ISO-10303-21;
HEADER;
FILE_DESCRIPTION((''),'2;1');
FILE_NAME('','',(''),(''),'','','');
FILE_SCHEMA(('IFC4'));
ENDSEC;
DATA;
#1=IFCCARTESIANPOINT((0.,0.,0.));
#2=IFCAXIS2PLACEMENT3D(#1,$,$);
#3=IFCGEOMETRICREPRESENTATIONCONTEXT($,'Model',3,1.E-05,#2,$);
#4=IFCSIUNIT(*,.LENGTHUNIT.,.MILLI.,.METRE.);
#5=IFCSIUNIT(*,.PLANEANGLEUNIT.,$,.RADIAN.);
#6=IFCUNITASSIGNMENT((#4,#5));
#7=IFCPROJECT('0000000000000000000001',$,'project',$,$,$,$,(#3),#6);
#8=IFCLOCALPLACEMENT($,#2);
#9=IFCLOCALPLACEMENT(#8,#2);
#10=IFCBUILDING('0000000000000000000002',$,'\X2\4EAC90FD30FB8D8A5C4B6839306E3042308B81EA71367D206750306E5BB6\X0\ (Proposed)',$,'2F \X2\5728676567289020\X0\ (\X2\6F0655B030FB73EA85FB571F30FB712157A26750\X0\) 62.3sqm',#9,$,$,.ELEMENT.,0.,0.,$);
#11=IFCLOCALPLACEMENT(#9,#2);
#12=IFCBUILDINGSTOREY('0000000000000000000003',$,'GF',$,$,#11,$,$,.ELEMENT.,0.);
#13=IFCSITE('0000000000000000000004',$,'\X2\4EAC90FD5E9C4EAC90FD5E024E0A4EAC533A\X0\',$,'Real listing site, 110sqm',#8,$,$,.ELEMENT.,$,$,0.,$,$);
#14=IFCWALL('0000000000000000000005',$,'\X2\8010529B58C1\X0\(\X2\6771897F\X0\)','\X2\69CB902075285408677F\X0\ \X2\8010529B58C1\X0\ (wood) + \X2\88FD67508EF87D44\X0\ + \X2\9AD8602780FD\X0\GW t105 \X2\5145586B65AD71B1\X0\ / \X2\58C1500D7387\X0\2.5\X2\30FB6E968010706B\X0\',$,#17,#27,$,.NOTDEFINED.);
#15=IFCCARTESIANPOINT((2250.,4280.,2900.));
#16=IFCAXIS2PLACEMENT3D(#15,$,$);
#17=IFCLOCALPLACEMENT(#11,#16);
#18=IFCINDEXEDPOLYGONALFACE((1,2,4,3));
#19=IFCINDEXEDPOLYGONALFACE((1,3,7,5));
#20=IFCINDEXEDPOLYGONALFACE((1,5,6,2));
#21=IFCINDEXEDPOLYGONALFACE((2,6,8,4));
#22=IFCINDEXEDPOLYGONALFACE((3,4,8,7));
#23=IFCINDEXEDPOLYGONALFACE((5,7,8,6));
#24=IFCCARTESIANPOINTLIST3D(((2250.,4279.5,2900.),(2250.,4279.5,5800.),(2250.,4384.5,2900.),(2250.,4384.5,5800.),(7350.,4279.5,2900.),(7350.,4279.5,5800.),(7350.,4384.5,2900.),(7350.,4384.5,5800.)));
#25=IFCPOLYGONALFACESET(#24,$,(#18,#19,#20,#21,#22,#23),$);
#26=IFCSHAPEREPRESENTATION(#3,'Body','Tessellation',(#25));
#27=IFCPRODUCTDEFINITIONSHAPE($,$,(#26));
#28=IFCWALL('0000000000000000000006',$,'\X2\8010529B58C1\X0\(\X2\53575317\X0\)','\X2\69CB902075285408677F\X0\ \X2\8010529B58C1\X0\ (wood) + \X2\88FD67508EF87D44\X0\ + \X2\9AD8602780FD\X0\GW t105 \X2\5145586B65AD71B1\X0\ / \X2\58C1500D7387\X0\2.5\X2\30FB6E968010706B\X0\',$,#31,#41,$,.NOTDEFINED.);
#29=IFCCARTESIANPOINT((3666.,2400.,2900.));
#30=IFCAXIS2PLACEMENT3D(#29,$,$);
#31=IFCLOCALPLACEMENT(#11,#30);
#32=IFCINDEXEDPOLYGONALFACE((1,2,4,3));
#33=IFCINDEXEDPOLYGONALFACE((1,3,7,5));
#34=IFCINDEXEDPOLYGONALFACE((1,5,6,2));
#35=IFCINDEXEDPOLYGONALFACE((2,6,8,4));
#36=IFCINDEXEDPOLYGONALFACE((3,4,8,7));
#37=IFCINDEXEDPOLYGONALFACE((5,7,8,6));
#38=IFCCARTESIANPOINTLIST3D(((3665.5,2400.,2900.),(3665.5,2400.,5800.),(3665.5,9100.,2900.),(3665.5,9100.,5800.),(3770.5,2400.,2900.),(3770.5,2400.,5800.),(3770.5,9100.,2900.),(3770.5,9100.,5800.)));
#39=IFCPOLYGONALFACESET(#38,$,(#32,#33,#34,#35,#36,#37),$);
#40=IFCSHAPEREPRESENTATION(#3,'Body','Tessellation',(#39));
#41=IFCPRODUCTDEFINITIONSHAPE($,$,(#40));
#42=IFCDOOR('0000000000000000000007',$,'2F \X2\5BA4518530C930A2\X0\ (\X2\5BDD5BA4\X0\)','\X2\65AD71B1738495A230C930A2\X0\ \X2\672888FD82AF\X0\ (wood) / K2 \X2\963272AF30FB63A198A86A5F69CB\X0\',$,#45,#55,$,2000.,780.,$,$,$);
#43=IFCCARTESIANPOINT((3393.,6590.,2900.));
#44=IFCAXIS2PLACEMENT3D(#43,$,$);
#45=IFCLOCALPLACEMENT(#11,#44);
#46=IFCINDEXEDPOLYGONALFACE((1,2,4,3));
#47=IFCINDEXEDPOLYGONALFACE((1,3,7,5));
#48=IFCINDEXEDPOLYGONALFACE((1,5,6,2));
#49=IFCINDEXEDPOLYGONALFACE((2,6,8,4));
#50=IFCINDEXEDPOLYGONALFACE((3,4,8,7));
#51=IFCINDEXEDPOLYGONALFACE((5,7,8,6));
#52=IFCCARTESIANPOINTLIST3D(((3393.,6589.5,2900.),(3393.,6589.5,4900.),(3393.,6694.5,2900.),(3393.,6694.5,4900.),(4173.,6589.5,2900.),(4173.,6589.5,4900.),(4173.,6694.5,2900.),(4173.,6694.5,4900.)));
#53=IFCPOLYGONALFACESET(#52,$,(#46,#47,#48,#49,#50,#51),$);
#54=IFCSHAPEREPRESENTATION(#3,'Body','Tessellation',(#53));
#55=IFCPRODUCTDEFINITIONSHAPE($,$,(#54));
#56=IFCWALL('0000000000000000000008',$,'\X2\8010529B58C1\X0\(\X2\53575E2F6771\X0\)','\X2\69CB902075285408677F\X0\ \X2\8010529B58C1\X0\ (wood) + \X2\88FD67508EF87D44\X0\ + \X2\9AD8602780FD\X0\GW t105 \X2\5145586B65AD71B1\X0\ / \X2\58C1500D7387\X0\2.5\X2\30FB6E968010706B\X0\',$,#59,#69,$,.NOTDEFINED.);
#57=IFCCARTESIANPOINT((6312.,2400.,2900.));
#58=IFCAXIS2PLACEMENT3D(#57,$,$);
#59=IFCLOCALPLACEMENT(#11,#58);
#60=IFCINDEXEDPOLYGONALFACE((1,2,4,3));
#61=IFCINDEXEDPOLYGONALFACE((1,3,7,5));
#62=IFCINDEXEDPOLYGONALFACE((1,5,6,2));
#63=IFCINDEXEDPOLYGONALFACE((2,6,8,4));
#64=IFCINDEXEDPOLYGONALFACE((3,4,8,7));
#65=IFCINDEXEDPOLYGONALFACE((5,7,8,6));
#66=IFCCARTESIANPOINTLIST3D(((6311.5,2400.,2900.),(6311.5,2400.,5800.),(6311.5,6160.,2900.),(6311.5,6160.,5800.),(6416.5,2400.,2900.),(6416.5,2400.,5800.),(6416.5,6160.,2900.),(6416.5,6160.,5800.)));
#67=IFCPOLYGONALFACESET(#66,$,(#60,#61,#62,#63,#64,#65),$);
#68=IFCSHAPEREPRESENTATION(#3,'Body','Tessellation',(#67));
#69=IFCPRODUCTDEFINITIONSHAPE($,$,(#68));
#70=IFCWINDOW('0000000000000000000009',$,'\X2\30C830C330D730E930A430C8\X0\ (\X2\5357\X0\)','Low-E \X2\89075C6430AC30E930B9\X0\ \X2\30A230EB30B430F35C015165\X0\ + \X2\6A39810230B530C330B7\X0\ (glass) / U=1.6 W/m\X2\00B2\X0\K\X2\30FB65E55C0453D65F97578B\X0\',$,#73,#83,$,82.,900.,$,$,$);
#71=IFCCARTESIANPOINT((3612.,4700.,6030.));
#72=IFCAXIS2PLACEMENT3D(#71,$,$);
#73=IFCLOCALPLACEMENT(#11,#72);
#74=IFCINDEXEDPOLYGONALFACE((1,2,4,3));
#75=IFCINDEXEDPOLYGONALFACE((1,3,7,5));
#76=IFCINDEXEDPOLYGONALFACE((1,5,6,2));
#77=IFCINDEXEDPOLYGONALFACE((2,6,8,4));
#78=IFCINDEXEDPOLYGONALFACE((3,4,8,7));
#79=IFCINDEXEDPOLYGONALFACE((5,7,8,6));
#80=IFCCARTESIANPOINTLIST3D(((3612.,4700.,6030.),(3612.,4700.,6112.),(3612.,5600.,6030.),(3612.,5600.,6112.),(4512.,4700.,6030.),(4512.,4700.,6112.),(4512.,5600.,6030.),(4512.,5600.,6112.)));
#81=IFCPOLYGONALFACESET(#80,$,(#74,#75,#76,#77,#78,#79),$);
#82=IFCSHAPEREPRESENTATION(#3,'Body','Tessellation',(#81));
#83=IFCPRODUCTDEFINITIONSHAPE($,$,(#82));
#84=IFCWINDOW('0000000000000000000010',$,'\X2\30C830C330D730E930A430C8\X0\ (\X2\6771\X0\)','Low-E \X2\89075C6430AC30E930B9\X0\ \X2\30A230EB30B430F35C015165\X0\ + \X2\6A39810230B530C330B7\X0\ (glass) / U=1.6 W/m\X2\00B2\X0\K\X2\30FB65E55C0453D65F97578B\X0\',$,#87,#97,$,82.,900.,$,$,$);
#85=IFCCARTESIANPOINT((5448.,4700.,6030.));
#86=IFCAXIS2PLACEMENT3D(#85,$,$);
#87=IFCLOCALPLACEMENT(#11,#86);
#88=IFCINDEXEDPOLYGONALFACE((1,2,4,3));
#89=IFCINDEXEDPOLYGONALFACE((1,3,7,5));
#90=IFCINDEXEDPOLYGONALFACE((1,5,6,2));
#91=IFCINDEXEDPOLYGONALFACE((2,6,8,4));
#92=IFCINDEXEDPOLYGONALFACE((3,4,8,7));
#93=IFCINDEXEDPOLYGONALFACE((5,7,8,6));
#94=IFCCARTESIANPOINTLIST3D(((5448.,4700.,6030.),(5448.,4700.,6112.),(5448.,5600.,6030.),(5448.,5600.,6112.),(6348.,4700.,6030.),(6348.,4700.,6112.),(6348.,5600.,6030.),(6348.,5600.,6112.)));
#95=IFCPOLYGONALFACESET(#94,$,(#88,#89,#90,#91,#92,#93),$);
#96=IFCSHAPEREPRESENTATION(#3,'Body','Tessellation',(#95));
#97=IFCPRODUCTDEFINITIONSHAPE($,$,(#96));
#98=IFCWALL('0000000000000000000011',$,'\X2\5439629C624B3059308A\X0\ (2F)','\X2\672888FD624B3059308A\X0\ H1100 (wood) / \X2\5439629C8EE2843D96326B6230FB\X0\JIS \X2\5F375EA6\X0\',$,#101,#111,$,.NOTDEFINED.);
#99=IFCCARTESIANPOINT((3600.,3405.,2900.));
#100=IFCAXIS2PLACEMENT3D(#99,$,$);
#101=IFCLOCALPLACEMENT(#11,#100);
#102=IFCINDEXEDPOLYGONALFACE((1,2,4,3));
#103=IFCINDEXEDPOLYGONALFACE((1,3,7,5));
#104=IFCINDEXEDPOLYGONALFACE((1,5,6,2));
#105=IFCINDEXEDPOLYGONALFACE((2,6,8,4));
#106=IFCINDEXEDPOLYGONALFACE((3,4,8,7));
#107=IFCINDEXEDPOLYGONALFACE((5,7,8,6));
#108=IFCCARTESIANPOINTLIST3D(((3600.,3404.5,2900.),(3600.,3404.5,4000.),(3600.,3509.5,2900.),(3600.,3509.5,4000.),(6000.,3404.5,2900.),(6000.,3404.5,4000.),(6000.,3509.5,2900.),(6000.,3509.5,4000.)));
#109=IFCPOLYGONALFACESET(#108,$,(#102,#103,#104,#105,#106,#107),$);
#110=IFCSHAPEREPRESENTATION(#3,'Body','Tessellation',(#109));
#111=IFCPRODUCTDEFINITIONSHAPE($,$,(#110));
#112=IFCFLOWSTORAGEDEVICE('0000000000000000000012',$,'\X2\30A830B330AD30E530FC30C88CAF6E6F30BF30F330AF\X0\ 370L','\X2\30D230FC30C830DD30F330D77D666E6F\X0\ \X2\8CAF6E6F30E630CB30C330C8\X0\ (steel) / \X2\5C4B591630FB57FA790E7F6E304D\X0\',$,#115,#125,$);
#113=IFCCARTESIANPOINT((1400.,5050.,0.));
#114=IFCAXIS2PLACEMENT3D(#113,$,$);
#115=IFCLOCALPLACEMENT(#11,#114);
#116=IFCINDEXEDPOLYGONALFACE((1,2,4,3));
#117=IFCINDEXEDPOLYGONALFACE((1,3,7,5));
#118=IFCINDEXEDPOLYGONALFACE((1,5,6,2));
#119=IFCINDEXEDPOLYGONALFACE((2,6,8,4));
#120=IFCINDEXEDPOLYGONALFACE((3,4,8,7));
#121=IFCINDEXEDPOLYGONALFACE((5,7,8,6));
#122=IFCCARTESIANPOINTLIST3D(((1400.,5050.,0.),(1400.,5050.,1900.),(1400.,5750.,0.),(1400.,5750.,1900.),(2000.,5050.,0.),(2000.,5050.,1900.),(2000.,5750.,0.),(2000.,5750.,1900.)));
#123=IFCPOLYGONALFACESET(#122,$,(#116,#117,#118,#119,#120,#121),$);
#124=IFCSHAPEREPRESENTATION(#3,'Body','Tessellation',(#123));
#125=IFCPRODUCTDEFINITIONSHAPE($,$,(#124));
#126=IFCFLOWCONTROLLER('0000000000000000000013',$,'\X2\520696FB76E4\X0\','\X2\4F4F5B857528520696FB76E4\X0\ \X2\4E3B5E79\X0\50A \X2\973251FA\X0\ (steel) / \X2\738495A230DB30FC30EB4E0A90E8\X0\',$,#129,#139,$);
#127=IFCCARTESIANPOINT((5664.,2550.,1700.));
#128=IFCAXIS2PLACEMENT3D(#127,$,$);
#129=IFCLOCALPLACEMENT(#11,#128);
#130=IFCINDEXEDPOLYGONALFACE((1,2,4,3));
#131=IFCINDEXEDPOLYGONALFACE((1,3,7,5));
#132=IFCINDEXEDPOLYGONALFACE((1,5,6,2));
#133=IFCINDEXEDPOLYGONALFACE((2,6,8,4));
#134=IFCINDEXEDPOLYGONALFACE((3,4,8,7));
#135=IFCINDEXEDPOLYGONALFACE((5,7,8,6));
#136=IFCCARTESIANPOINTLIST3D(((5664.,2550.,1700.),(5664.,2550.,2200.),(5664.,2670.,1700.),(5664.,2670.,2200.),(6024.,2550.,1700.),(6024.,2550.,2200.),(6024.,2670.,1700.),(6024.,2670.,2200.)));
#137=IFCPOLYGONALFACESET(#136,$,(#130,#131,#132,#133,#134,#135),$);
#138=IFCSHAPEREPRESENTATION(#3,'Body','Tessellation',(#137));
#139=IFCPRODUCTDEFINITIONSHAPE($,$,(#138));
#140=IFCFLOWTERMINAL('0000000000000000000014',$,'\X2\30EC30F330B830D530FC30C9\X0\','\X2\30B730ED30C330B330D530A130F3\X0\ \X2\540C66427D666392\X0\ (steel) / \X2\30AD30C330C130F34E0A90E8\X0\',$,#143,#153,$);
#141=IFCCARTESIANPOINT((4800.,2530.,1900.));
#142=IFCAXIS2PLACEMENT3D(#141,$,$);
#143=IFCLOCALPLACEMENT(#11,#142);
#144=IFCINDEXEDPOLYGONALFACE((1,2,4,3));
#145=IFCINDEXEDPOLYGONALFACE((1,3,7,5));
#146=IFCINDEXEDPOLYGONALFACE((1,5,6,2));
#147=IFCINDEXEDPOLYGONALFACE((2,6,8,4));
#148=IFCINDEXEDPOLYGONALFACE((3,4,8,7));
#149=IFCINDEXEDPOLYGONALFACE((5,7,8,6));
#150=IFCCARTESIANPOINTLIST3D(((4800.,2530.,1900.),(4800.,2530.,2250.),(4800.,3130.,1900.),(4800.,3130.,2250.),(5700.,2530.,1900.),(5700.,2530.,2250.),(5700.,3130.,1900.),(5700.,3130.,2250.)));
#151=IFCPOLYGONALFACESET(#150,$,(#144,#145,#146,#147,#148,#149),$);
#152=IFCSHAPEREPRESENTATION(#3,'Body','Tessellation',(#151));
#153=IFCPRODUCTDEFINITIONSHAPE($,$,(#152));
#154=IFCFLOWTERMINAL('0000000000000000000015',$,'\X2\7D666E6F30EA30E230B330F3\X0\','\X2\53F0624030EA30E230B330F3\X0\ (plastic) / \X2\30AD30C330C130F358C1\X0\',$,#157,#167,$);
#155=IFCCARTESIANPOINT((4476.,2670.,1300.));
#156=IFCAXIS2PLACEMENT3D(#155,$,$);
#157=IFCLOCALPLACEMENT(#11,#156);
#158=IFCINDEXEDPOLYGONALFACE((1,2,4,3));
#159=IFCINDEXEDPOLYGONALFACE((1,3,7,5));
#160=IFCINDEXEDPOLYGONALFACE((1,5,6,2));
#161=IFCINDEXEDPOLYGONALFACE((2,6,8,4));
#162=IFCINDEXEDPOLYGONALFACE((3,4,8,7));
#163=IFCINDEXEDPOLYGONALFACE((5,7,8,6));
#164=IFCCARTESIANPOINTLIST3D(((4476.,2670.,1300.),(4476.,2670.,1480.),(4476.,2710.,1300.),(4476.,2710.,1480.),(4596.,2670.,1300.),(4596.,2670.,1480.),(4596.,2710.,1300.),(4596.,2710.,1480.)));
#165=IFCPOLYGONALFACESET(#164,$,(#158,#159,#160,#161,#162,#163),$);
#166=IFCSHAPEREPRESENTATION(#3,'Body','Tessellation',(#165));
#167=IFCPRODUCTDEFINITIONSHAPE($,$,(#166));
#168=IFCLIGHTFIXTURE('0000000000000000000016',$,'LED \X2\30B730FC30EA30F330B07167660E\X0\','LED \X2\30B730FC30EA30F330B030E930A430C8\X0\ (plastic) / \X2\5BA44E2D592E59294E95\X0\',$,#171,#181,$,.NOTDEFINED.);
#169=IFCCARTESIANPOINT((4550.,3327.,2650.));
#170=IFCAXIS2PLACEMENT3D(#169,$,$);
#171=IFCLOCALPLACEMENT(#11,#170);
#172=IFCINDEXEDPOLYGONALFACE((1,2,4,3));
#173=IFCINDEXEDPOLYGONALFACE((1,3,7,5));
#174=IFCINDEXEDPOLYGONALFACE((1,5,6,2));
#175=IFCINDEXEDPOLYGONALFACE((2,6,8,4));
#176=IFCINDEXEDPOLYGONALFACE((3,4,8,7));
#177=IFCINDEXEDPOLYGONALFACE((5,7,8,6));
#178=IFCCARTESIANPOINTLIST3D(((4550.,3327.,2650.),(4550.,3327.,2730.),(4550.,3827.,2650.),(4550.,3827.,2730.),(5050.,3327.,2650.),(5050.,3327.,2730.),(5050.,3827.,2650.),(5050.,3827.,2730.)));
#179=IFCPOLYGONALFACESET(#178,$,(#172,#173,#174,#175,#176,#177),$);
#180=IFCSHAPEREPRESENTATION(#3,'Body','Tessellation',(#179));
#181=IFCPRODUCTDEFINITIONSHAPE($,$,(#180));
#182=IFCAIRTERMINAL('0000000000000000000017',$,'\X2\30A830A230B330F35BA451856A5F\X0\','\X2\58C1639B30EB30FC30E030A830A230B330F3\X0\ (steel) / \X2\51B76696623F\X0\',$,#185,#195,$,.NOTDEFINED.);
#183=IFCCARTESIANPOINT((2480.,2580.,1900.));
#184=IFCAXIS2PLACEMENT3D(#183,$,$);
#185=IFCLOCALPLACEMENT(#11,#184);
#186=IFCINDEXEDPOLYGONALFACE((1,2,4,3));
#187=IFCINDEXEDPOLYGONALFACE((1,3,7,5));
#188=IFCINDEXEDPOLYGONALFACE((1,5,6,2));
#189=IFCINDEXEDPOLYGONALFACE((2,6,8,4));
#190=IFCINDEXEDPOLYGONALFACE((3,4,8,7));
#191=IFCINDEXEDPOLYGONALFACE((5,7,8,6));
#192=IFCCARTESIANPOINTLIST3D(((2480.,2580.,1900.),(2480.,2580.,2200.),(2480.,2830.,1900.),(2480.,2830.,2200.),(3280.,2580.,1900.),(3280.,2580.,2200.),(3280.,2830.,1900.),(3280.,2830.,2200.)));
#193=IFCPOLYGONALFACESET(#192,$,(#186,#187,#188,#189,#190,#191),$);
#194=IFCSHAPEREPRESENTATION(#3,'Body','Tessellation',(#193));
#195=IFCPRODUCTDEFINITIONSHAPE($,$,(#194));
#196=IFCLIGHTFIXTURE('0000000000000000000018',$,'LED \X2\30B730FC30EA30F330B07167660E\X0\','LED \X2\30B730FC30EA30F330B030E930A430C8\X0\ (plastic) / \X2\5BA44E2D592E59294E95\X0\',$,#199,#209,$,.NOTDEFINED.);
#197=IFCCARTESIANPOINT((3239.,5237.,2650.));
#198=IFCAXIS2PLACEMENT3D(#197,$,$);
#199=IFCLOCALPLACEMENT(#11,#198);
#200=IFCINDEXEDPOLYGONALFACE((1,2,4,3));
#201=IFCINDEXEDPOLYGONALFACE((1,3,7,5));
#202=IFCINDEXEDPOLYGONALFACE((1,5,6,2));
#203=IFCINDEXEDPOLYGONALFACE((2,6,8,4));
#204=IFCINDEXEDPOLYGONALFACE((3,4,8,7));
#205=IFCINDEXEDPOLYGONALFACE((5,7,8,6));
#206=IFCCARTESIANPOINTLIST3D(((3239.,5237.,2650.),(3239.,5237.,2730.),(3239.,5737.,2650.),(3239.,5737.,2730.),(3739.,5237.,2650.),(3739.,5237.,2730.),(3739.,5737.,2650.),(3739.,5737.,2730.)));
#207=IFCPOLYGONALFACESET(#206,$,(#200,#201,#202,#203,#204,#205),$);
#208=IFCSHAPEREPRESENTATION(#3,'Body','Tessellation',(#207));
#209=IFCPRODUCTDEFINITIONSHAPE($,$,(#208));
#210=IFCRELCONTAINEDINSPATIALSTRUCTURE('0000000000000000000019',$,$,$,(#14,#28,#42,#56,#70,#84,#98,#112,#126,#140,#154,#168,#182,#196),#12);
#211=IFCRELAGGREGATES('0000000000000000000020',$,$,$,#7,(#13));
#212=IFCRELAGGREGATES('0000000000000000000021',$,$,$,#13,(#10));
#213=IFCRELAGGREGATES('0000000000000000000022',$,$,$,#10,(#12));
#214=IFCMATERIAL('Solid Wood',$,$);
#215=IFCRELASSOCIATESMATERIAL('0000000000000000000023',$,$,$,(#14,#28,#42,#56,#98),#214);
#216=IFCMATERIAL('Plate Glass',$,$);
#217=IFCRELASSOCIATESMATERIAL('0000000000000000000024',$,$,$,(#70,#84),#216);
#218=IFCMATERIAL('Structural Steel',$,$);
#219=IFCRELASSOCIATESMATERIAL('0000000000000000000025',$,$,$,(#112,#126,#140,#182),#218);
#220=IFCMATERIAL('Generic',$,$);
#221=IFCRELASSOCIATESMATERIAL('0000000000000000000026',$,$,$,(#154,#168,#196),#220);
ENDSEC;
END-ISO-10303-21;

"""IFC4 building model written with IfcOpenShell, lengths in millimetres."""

from ifc_helpers import new_model, si_unit, frame, frame_2d, origin, place, context, project, spatial, rectangle, extrude, material, element, fill, save


model = new_model("IFC4")

# Units and contexts
model_context = context("Model", 3, precision=1e-05, world=origin())
ifc_project = project(units=[si_unit("LENGTHUNIT", "METRE", prefix="MILLI"), si_unit("PLANEANGLEUNIT", "RADIAN")], contexts=[model_context])

# Site, building, storey
site_placement = place(None, origin())
site = spatial("IfcSite", under=ifc_project, at=site_placement, Name="京都府京都市上京区", ObjectType="Real listing site, 110sqm", CompositionType="ELEMENT", RefElevation=0.0)
building_placement = place(site_placement, origin())
building = spatial("IfcBuilding", under=site, at=building_placement, Name="京都・越屋根のある自然素材の家 (Proposed)", ObjectType="2F 在来木造 (漆喰・珪藻土・無垢材) 62.3sqm", CompositionType="ELEMENT", ElevationOfRefHeight=0.0, ElevationOfTerrain=0.0)
storey_placement = place(building_placement, origin())
storey = spatial("IfcBuildingStorey", under=building, at=storey_placement, Name="GF", CompositionType="ELEMENT", Elevation=0.0)

# Shared definitions
ifc_material_1 = material(Name="Solid Wood")

# Wall
wall_1_placement = place(storey_placement, frame((2250.0, 4280.0, 2900.0)))
element("IfcWall", 1, at=wall_1_placement, inside=storey, material=ifc_material_1, Name="耐力壁(東西)", Description="構造用合板 耐力壁 (wood) + 製材軸組 + 高性能GW t105 充填断熱 / 壁倍率2.5・準耐火", PredefinedType="NOTDEFINED", context=model_context, shape_type="SweptSolid", body=[
    extrude(rectangle(XDim=5100.0, YDim=105.0, at=frame_2d((2550.0, 52.0))), frame((2250.0, 4280.0, 2900.0)), (0.0, 0.0, 1.0), 2900.0),
])

# Wall, opening, door
wall_2_placement = place(storey_placement, frame((3666.0, 2400.0, 2900.0)))
wall_2 = element("IfcWall", 2, at=wall_2_placement, inside=storey, material=ifc_material_1, Name="耐力壁(南北)", Description="構造用合板 耐力壁 (wood) + 製材軸組 + 高性能GW t105 充填断熱 / 壁倍率2.5・準耐火", PredefinedType="NOTDEFINED", context=model_context, shape_type="SweptSolid", body=[
    extrude(rectangle(XDim=105.0, YDim=6700.0, at=frame_2d((52.0, 3350.0))), frame((3666.0, 2400.0, 2900.0)), (0.0, 0.0, 1.0), 2900.0),
])
opening_placement = place(storey_placement, frame((3393.0, 6590.0, 2900.0)))
opening = element("IfcOpeningElement", 3, at=opening_placement, cuts=wall_2, PredefinedType="NOTDEFINED", context=model_context, shape_type="SweptSolid", body=[
    extrude(rectangle(XDim=780.0, YDim=105.0, at=frame_2d((390.0, 52.0))), frame((3393.0, 6590.0, 2900.0)), (0.0, 0.0, 1.0), 2000.0),
])
door_placement = place(storey_placement, frame((3393.0, 6590.0, 2900.0)))
door = element("IfcDoor", 4, at=door_placement, inside=storey, material=ifc_material_1, Name="2F 室内ドア (寝室)", Description="断熱玄関ドア 木製芯 (wood) / K2 防犯・採風機構", OverallHeight=2000.0, OverallWidth=780.0, context=model_context, shape_type="SweptSolid", body=[
    extrude(rectangle(XDim=780.0, YDim=105.0, at=frame_2d((390.0, 52.0))), frame((3393.0, 6590.0, 2900.0)), (0.0, 0.0, 1.0), 2000.0),
])
fill(opening, door)

# Wall
wall_3_placement = place(storey_placement, frame((6312.0, 2400.0, 2900.0)))
element("IfcWall", 5, at=wall_3_placement, inside=storey, material=ifc_material_1, Name="耐力壁(南帯東)", Description="構造用合板 耐力壁 (wood) + 製材軸組 + 高性能GW t105 充填断熱 / 壁倍率2.5・準耐火", PredefinedType="NOTDEFINED", context=model_context, shape_type="SweptSolid", body=[
    extrude(rectangle(XDim=105.0, YDim=3760.0, at=frame_2d((52.0, 1880.0))), frame((6312.0, 2400.0, 2900.0)), (0.0, 0.0, 1.0), 2900.0),
])

# Windows
ifc_material_2 = material(Name="Plate Glass")
window_1_placement = place(storey_placement, frame((3612.0, 4700.0, 6030.0)))
element("IfcWindow", 6, at=window_1_placement, inside=storey, material=ifc_material_2, Name="トップライト (南)", Description="Low-E 複層ガラス アルゴン封入 + 樹脂サッシ (glass) / U=1.6 W/m²K・日射取得型", OverallHeight=82.0, OverallWidth=900.0, context=model_context, shape_type="SweptSolid", body=[
    extrude(rectangle(XDim=900.0, YDim=900.0, at=frame_2d((450.0, 450.0))), frame((3612.0, 4700.0, 6030.0)), (0.0, 0.0, 1.0), 82.0),
])
window_2_placement = place(storey_placement, frame((5448.0, 4700.0, 6030.0)))
element("IfcWindow", 7, at=window_2_placement, inside=storey, material=ifc_material_2, Name="トップライト (東)", Description="Low-E 複層ガラス アルゴン封入 + 樹脂サッシ (glass) / U=1.6 W/m²K・日射取得型", OverallHeight=82.0, OverallWidth=900.0, context=model_context, shape_type="SweptSolid", body=[
    extrude(rectangle(XDim=900.0, YDim=900.0, at=frame_2d((450.0, 450.0))), frame((5448.0, 4700.0, 6030.0)), (0.0, 0.0, 1.0), 82.0),
])

# Wall
wall_4_placement = place(storey_placement, frame((3600.0, 3405.0, 2900.0)))
element("IfcWall", 8, at=wall_4_placement, inside=storey, material=ifc_material_1, Name="吹抜手すり (2F)", Description="木製手すり H1100 (wood) / 吹抜転落防止・JIS 強度", PredefinedType="NOTDEFINED", context=model_context, shape_type="SweptSolid", body=[
    extrude(rectangle(XDim=2400.0, YDim=105.0, at=frame_2d((1200.0, 52.0))), frame((3600.0, 3405.0, 2900.0)), (0.0, 0.0, 1.0), 1100.0),
])

# Flow storage device
ifc_material_3 = material(Name="Structural Steel")
flow_storage_device_placement = place(storey_placement, frame((1400.0, 5050.0, 0.0)))
element("IfcFlowStorageDevice", 9, at=flow_storage_device_placement, inside=storey, material=ifc_material_3, Name="エコキュート貯湯タンク 370L", Description="ヒートポンプ給湯 貯湯ユニット (steel) / 屋外・基礎置き", context=model_context, shape_type="SweptSolid", body=[
    extrude(rectangle(XDim=600.0, YDim=700.0, at=frame_2d((300.0, 350.0))), frame((1400.0, 5050.0, 0.0)), (0.0, 0.0, 1.0), 1900.0),
])

# Flow controller
flow_controller_placement = place(storey_placement, frame((5664.0, 2550.0, 1700.0)))
element("IfcFlowController", 10, at=flow_controller_placement, inside=storey, material=ifc_material_3, Name="分電盤", Description="住宅用分電盤 主幹50A 露出 (steel) / 玄関ホール上部", context=model_context, shape_type="SweptSolid", body=[
    extrude(rectangle(XDim=360.0, YDim=120.0, at=frame_2d((180.0, 60.0))), frame((5664.0, 2550.0, 1700.0)), (0.0, 0.0, 1.0), 500.0),
])

# Flow terminals
flow_terminal_1_placement = place(storey_placement, frame((4800.0, 2530.0, 1900.0)))
element("IfcFlowTerminal", 11, at=flow_terminal_1_placement, inside=storey, material=ifc_material_3, Name="レンジフード", Description="シロッコファン 同時給排 (steel) / キッチン上部", context=model_context, shape_type="SweptSolid", body=[
    extrude(rectangle(XDim=900.0, YDim=600.0, at=frame_2d((450.0, 300.0))), frame((4800.0, 2530.0, 1900.0)), (0.0, 0.0, 1.0), 350.0),
])
ifc_material_4 = material(Name="Generic")
flow_terminal_2_placement = place(storey_placement, frame((4476.0, 2670.0, 1300.0)))
element("IfcFlowTerminal", 12, at=flow_terminal_2_placement, inside=storey, material=ifc_material_4, Name="給湯リモコン", Description="台所リモコン (plastic) / キッチン壁", context=model_context, shape_type="SweptSolid", body=[
    extrude(rectangle(XDim=120.0, YDim=40.0, at=frame_2d((60.0, 20.0))), frame((4476.0, 2670.0, 1300.0)), (0.0, 0.0, 1.0), 180.0),
])

# Light fixture
light_fixture_1_placement = place(storey_placement, frame((4550.0, 3327.0, 2650.0)))
element("IfcLightFixture", 13, at=light_fixture_1_placement, inside=storey, material=ifc_material_4, Name="LED シーリング照明", Description="LED シーリングライト (plastic) / 室中央天井", PredefinedType="NOTDEFINED", context=model_context, shape_type="SweptSolid", body=[
    extrude(rectangle(XDim=500.0, YDim=500.0, at=frame_2d((250.0, 250.0))), frame((4550.0, 3327.0, 2650.0)), (0.0, 0.0, 1.0), 80.0),
])

# Air terminal
air_terminal_1_placement = place(storey_placement, frame((2480.0, 2580.0, 1900.0)))
element("IfcAirTerminal", 14, at=air_terminal_1_placement, inside=storey, material=ifc_material_3, Name="エアコン室内機", Description="壁掛ルームエアコン (steel) / 冷暖房", PredefinedType="NOTDEFINED", context=model_context, shape_type="SweptSolid", body=[
    extrude(rectangle(XDim=800.0, YDim=250.0, at=frame_2d((400.0, 125.0))), frame((2480.0, 2580.0, 1900.0)), (0.0, 0.0, 1.0), 300.0),
])

# Light fixture
light_fixture_2_placement = place(storey_placement, frame((3239.0, 5237.0, 2650.0)))
element("IfcLightFixture", 15, at=light_fixture_2_placement, inside=storey, material=ifc_material_4, Name="LED シーリング照明", Description="LED シーリングライト (plastic) / 室中央天井", PredefinedType="NOTDEFINED", context=model_context, shape_type="SweptSolid", body=[
    extrude(rectangle(XDim=500.0, YDim=500.0, at=frame_2d((250.0, 250.0))), frame((3239.0, 5237.0, 2650.0)), (0.0, 0.0, 1.0), 80.0),
])

save(model, "model.ifc")
